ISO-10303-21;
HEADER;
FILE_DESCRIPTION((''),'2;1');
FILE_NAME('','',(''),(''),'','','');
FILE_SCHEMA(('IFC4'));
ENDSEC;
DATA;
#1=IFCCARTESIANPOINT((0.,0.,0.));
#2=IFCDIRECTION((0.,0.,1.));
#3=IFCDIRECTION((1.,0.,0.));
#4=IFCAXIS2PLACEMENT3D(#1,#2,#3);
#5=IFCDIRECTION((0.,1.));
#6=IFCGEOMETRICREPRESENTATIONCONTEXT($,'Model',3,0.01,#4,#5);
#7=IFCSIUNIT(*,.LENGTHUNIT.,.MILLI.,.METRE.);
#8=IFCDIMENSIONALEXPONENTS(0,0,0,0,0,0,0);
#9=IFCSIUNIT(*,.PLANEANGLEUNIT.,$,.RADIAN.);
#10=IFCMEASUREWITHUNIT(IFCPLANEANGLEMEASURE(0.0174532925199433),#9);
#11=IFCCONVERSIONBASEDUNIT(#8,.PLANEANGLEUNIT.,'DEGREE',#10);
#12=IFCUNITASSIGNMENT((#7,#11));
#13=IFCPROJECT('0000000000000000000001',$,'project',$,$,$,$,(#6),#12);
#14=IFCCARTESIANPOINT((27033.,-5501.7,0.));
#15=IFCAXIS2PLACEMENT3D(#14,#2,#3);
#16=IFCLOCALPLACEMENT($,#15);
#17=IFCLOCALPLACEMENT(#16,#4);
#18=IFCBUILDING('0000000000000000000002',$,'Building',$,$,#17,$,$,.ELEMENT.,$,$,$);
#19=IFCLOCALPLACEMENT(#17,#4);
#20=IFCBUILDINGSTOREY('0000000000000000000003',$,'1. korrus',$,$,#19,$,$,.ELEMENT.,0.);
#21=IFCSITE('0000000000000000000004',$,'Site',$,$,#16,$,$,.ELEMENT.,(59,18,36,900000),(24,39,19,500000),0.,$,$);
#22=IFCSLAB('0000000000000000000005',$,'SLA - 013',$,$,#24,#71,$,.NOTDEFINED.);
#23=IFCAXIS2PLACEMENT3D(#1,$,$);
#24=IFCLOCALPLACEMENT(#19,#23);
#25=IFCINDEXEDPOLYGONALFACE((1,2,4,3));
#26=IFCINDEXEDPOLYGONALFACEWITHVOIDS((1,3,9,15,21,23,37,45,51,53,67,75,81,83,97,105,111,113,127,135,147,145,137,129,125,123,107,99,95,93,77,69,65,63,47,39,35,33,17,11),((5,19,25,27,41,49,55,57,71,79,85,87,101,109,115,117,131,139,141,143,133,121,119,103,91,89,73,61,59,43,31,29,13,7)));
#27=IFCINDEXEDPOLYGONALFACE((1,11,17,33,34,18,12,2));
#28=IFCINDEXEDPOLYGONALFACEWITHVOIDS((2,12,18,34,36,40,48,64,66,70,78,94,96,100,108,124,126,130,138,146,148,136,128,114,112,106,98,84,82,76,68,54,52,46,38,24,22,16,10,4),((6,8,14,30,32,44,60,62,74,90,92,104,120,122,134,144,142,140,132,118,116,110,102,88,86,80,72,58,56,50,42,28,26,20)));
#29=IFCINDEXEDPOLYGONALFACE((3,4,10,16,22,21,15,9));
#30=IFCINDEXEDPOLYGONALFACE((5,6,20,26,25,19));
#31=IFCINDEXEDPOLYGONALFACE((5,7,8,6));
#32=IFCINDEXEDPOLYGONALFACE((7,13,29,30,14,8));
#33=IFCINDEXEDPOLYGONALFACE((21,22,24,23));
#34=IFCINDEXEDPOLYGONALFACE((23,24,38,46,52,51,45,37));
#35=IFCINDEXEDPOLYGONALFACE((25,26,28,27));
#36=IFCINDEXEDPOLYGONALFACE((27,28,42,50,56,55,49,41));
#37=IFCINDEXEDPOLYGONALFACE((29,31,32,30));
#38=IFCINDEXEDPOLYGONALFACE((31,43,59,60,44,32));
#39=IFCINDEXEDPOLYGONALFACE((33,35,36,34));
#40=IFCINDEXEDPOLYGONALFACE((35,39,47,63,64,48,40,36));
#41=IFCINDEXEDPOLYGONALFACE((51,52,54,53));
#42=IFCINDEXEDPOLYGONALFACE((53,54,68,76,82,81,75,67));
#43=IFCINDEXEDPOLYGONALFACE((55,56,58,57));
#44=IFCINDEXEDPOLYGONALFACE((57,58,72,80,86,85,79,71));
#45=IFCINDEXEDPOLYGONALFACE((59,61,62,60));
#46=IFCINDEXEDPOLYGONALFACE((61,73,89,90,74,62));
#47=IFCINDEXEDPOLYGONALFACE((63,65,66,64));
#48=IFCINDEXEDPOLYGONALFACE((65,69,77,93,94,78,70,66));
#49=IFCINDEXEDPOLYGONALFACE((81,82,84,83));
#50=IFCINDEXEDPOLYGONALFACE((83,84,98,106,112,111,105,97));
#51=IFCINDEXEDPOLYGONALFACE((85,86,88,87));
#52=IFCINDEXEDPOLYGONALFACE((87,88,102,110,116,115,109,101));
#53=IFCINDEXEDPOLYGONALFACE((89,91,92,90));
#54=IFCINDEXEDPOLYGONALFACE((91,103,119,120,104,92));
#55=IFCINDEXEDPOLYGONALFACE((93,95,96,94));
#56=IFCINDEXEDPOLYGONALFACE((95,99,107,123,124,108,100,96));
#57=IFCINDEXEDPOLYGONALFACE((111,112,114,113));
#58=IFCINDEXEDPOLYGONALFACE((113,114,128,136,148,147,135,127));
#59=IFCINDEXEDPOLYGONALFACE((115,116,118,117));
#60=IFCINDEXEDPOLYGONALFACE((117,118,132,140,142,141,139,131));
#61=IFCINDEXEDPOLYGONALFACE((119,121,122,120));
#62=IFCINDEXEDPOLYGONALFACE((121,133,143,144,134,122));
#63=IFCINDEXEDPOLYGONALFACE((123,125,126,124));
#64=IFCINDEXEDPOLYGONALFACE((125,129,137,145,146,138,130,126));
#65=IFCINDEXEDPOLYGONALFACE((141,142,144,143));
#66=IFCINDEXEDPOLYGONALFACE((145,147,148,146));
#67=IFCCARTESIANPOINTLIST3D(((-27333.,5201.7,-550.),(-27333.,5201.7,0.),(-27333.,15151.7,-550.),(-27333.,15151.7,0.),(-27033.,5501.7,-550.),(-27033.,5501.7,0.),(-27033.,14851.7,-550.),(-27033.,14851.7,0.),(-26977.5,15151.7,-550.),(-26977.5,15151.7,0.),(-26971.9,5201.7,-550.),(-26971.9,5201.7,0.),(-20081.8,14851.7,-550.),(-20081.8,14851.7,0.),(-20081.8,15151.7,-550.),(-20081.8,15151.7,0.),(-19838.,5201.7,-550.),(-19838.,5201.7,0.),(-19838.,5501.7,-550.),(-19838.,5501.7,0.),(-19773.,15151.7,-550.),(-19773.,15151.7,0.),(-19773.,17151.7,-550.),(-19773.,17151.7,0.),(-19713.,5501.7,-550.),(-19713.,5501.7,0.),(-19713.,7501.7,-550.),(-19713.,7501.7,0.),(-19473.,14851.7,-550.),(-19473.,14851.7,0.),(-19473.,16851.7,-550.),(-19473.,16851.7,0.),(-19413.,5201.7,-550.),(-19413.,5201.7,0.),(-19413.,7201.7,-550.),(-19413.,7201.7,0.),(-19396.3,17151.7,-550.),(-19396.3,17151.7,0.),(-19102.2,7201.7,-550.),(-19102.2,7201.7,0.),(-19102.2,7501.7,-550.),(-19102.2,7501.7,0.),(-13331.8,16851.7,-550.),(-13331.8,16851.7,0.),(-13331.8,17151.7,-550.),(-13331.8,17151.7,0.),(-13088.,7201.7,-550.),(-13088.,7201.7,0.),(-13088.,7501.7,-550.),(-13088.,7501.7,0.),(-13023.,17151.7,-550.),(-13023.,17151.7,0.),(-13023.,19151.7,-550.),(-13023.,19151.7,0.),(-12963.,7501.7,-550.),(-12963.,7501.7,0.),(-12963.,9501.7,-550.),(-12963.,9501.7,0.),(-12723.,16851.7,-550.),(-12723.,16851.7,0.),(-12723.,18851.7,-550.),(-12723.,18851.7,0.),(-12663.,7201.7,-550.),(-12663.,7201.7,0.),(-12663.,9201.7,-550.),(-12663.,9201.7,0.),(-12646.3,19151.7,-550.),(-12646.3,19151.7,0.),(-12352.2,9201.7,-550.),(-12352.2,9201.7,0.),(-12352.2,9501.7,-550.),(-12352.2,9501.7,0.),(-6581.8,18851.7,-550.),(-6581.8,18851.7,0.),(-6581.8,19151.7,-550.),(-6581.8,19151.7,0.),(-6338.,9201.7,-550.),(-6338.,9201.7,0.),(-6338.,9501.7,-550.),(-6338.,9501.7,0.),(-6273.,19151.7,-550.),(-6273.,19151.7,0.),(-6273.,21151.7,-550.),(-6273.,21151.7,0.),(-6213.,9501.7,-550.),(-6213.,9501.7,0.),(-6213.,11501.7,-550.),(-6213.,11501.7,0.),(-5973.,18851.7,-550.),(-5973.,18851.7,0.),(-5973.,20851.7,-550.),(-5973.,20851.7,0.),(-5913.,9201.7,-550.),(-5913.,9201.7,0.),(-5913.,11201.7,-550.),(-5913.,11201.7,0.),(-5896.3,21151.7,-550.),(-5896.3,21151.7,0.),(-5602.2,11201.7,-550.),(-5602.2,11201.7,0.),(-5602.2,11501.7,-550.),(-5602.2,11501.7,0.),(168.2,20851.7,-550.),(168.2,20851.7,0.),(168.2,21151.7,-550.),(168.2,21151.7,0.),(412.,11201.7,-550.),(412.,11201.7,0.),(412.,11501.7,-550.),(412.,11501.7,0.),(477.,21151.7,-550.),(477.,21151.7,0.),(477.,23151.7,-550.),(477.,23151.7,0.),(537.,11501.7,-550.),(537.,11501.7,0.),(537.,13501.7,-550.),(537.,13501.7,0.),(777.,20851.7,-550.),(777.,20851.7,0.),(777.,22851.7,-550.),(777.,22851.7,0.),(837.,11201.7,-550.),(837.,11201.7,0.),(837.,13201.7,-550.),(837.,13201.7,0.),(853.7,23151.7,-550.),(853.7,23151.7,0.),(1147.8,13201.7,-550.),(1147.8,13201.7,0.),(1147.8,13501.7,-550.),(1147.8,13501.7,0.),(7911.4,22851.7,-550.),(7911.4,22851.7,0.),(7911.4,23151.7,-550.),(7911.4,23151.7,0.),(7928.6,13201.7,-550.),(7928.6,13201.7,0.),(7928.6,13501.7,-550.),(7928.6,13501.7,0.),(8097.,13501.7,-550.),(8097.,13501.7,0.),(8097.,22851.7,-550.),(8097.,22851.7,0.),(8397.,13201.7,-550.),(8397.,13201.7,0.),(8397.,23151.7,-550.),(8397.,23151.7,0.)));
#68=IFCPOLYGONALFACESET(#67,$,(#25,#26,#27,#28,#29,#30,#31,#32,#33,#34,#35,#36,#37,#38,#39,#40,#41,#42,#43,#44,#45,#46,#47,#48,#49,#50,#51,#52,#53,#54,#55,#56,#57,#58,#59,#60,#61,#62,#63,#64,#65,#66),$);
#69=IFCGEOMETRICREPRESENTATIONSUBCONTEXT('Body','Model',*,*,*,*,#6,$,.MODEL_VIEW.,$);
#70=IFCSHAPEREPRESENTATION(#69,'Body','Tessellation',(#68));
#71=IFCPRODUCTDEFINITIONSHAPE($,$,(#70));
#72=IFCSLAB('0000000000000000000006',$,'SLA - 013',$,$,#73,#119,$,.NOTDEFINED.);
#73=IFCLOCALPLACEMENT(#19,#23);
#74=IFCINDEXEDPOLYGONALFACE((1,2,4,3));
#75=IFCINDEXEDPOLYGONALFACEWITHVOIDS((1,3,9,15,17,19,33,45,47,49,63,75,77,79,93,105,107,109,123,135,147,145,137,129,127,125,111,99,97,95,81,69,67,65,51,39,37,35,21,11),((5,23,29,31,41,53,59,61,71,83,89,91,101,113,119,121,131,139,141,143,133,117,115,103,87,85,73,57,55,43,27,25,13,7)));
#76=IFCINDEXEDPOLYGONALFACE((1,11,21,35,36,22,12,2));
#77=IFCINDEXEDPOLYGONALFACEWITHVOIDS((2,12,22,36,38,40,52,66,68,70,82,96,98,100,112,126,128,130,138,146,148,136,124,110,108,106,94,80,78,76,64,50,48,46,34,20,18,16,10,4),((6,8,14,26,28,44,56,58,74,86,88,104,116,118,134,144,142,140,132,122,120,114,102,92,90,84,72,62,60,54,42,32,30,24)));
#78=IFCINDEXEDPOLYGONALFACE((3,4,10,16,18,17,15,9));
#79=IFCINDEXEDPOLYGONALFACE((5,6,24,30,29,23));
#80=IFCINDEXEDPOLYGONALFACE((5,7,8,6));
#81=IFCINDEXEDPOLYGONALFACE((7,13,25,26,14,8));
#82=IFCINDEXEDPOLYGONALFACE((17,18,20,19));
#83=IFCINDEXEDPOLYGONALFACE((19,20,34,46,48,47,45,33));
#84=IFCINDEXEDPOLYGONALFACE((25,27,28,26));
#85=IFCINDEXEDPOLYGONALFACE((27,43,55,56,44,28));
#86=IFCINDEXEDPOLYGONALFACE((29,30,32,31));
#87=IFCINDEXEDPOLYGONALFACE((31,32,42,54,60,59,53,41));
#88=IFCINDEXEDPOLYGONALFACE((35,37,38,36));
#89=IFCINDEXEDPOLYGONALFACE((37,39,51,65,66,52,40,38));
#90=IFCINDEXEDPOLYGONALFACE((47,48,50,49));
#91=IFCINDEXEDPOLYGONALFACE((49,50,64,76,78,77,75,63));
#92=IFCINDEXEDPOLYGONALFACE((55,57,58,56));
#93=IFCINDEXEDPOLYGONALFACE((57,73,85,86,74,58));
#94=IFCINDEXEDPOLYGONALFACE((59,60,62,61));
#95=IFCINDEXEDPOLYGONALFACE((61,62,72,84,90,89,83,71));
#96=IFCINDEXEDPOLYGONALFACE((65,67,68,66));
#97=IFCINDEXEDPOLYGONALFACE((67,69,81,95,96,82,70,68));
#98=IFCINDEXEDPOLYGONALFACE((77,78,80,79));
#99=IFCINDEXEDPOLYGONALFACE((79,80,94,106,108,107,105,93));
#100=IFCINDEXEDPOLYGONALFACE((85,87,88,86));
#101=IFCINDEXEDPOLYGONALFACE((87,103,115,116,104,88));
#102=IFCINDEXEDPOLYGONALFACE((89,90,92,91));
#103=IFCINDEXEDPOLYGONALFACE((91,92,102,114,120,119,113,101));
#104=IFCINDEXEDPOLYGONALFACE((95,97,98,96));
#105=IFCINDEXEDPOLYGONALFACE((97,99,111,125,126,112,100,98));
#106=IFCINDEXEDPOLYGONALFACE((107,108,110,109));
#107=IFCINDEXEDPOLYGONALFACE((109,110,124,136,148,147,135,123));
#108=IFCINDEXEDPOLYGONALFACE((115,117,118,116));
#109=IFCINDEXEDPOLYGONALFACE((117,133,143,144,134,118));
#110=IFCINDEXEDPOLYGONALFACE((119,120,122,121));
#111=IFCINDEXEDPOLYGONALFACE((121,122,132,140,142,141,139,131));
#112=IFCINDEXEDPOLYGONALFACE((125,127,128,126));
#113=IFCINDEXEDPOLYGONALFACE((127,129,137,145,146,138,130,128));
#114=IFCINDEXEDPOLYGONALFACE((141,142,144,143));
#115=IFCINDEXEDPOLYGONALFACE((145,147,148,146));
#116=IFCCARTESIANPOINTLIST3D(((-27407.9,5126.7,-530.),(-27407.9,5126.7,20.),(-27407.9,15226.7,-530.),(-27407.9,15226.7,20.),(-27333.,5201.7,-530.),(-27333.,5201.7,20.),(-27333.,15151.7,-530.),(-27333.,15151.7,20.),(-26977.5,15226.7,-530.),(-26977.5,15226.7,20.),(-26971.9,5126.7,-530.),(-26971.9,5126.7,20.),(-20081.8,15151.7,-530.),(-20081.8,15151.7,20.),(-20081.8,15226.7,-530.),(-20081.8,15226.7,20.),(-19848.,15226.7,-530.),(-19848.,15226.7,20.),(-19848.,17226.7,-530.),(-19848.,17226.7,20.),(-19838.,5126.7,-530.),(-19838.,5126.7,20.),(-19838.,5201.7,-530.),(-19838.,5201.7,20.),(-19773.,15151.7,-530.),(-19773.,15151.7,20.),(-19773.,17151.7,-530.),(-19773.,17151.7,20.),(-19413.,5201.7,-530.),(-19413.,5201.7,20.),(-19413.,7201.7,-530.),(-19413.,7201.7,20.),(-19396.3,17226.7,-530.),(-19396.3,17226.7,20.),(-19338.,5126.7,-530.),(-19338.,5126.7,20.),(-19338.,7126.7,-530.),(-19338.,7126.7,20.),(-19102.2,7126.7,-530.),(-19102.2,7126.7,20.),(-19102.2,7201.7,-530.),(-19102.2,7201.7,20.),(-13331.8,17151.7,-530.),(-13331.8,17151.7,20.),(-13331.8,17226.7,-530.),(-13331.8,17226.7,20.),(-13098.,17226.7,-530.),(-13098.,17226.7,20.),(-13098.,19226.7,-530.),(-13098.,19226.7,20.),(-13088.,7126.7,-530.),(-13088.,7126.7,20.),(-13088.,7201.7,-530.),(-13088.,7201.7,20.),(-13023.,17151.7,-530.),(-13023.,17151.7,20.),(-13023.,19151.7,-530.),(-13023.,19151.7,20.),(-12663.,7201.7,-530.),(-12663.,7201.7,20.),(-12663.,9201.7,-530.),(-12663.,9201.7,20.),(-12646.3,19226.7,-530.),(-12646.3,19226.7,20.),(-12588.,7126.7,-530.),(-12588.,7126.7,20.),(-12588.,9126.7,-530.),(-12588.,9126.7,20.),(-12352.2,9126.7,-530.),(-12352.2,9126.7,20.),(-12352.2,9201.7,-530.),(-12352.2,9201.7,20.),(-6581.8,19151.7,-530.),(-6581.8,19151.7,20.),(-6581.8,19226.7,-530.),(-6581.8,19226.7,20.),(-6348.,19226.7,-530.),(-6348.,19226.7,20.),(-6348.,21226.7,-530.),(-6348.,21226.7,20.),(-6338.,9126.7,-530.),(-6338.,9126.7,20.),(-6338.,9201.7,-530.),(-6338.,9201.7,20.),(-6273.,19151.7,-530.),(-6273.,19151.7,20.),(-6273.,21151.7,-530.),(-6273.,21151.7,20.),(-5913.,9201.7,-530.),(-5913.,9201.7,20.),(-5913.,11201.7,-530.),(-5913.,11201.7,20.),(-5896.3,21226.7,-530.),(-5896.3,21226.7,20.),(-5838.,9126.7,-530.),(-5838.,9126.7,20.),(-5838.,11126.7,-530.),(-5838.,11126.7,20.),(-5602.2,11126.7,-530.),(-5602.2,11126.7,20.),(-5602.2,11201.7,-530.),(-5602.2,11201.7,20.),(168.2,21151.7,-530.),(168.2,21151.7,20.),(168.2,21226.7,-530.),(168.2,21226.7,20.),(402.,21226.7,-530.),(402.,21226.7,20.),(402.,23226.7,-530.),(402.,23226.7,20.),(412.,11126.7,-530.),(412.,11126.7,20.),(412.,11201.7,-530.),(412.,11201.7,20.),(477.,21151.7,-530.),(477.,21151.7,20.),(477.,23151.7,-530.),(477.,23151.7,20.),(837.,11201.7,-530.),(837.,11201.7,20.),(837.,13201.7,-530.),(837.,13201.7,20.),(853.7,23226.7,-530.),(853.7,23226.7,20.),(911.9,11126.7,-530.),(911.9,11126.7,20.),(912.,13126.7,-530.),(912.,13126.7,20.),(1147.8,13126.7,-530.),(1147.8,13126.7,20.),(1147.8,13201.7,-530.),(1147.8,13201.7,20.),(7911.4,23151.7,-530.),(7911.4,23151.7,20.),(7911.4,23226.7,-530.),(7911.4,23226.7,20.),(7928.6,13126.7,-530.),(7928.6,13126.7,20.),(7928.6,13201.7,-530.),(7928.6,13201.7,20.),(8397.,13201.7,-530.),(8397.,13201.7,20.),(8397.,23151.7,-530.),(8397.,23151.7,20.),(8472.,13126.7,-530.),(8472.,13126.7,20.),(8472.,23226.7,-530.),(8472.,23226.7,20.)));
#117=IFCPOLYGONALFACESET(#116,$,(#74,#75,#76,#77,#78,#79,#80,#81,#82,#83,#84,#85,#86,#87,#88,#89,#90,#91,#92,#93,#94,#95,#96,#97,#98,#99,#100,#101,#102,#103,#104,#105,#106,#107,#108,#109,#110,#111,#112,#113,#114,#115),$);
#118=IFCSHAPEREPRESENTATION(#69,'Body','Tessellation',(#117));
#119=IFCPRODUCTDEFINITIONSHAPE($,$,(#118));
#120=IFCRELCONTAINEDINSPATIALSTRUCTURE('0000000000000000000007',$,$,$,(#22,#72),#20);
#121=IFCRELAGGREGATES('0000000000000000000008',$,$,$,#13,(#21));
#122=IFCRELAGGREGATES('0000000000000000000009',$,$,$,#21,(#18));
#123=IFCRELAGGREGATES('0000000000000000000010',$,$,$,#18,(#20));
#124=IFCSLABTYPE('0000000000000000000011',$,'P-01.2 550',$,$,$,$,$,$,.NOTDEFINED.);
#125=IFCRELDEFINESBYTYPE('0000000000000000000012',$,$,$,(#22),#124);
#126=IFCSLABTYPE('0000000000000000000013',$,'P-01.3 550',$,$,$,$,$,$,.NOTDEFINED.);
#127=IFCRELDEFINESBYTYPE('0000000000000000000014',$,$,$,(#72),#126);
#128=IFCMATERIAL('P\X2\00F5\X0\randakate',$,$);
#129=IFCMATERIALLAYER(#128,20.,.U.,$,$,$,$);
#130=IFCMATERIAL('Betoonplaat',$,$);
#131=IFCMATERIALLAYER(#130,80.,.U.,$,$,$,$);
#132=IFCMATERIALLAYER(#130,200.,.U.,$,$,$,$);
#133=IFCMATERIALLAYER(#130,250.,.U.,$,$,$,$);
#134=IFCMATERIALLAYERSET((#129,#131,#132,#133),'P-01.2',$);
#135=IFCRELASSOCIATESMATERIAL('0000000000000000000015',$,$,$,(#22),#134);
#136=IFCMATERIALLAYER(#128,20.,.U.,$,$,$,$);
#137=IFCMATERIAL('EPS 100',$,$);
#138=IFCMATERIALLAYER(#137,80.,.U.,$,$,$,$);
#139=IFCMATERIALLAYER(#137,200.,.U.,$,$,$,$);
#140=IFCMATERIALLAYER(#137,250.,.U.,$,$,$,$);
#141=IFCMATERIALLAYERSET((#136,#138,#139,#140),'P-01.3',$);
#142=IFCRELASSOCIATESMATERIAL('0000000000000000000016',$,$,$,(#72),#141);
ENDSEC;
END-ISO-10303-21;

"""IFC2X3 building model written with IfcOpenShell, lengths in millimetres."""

from ifc_helpers import new_model, entity, si_unit, converted_unit, direction, frame, origin_with_axes, place, context, subcontext, project, spatial, polyline, outline, extrude, material, layer, layer_set, layer_usage, type_object, element, save


model = new_model("IFC2X3")

# Units and contexts
model_context = context("Model", 3, precision=0.01, world=origin_with_axes(), true_north=direction((0.0, 1.0)))
body_context = subcontext(model_context, "Body", "Model", "MODEL_VIEW")
ifc_project = project(units=[si_unit("LENGTHUNIT", "METRE", prefix="MILLI"), converted_unit("PLANEANGLEUNIT", "DEGREE", entity("IfcPlaneAngleMeasure", 0.0174532925199433), si_unit("PLANEANGLEUNIT", "RADIAN"), dimensions=[0, 0, 0, 0, 0, 0, 0])], contexts=[model_context])

# Site, building, storey
site_placement = place(None, frame((27033.0, -5501.7, 0.0), z_axis=(0.0, 0.0, 1.0), x_axis=(1.0, 0.0, 0.0)))
site = spatial("IfcSite", under=ifc_project, at=site_placement, Name="Site", CompositionType="ELEMENT", RefLatitude=(59, 18, 36, 900000), RefLongitude=(24, 39, 19, 500000), RefElevation=0.0)
building_placement = place(site_placement, origin_with_axes())
building = spatial("IfcBuilding", under=site, at=building_placement, Name="Building", CompositionType="ELEMENT")
storey_placement = place(building_placement, origin_with_axes())
storey = spatial("IfcBuildingStorey", under=building, at=storey_placement, Name="1. korrus", CompositionType="ELEMENT", Elevation=0.0)

# Slabs
ifc_material_1 = material(Name="Põrandakate")
ifc_material_2 = material(Name="Betoonplaat")
ifc_material_3 = material(Name="EPS 100")
ifc_layer_1 = layer(ifc_material_1, 20.0, ventilated="UNKNOWN")
ifc_layer_2 = layer(ifc_material_2, 80.0, ventilated="UNKNOWN")
ifc_layer_3 = layer(ifc_material_2, 200.0, ventilated="UNKNOWN")
ifc_layer_4 = layer(ifc_material_2, 250.0, ventilated="UNKNOWN")
ifc_layer_set_1 = layer_set([ifc_layer_1, ifc_layer_2, ifc_layer_3, ifc_layer_4], Name="P-01.2")
ifc_layer_usage_1 = layer_usage(ifc_layer_set_1, "AXIS3", "NEGATIVE", 550.0)
slab_type_1 = type_object("IfcSlabType", Name="P-01.2 550", PredefinedType="NOTDEFINED")
slab_1_placement = place(storey_placement, frame((-26977.5, 15151.7, 0.0), z_axis=(0.0, 0.0, 1.0), x_axis=(1.0, 0.0, 0.0)))
element("IfcSlab", 1, at=slab_1_placement, inside=storey, type_object=slab_type_1, material=ifc_layer_usage_1, Name="SLA - 013", PredefinedType="NOTDEFINED", context=body_context, shape_type="SweptSolid", body=[
    extrude(outline(polyline([(0.0, 0.0), (-355.5, 0.0), (-355.5, -9950.0), (5.5, -9950.0), (7139.5, -9950.0), (7564.5, -9950.0), (7564.5, -7950.0), (7875.3, -7950.0), (13889.5, -7950.0), (14314.5, -7950.0), (14314.5, -5950.0), (14625.3, -5950.0), (20639.5, -5950.0), (21064.5, -5950.0), (21064.5, -3950.0), (21375.3, -3950.0), (27389.4, -3950.0), (27814.4, -3950.0), (27814.5, -1950.0), (28125.2, -1950.0), (34906.0, -1950.0), (35374.5, -1950.0), (35374.5, 8000.0), (34888.8, 8000.0), (27831.1, 8000.0), (27454.5, 8000.0), (27454.5, 6000.0), (27145.6, 6000.0), (21081.1, 6000.0), (20704.5, 6000.0), (20704.5, 4000.0), (20395.6, 4000.0), (14331.1, 4000.0), (13954.5, 4000.0), (13954.5, 2000.0), (13645.6, 2000.0), (7581.1, 2000.0), (7204.5, 2000.0), (7204.5, 0.0), (6895.6, 0.0), (0.0, 0.0)]), holes=[polyline([(7139.5, -9650.0), (-55.5, -9650.0), (-55.5, -300.0), (6895.6, -300.0), (7504.5, -300.0), (7504.5, 1700.0), (13645.6, 1700.0), (14254.5, 1700.0), (14254.5, 3700.0), (20395.6, 3700.0), (21004.5, 3700.0), (21004.5, 5700.0), (27145.6, 5700.0), (27754.5, 5700.0), (27754.5, 7700.0), (34888.8, 7700.0), (35074.5, 7700.0), (35074.5, -1650.0), (34906.0, -1650.0), (28125.2, -1650.0), (27514.5, -1650.0), (27514.4, -3650.0), (27389.4, -3650.0), (21375.3, -3650.0), (20764.5, -3650.0), (20764.5, -5650.0), (20639.5, -5650.0), (14625.3, -5650.0), (14014.5, -5650.0), (14014.5, -7650.0), (13889.5, -7650.0), (7875.3, -7650.0), (7264.5, -7650.0), (7264.5, -9650.0), (7139.5, -9650.0)])]), frame((0.0, 0.0, -550.0), z_axis=(0.0, 0.0, 1.0), x_axis=(1.0, 0.0, 0.0)), (0.0, 0.0, 1.0), 550.0),
])
ifc_layer_5 = layer(ifc_material_1, 20.0, ventilated="UNKNOWN")
ifc_layer_6 = layer(ifc_material_3, 80.0, ventilated="UNKNOWN")
ifc_layer_7 = layer(ifc_material_3, 200.0, ventilated="UNKNOWN")
ifc_layer_8 = layer(ifc_material_3, 250.0, ventilated="UNKNOWN")
ifc_layer_set_2 = layer_set([ifc_layer_5, ifc_layer_6, ifc_layer_7, ifc_layer_8], Name="P-01.3")
ifc_layer_usage_2 = layer_usage(ifc_layer_set_2, "AXIS3", "NEGATIVE", 550.0)
slab_type_2 = type_object("IfcSlabType", Name="P-01.3 550", PredefinedType="NOTDEFINED")
slab_2_placement = place(storey_placement, frame((-26977.5, 15226.7, 0.0), z_axis=(0.0, 0.0, 1.0), x_axis=(1.0, 0.0, 0.0)))
element("IfcSlab", 2, at=slab_2_placement, inside=storey, type_object=slab_type_2, material=ifc_layer_usage_2, Name="SLA - 013", PredefinedType="NOTDEFINED", context=body_context, shape_type="SweptSolid", body=[
    extrude(outline(polyline([(0.0, 0.0), (-430.5, 0.0), (-430.5, -10099.9), (5.5, -10099.9), (7139.5, -10099.9), (7639.4, -10099.9), (7639.4, -8099.9), (7875.3, -8099.9), (13889.5, -8099.9), (14389.4, -8099.9), (14389.4, -6099.9), (14625.3, -6099.9), (20639.5, -6099.9), (21139.4, -6099.9), (21139.4, -4099.9), (21375.3, -4099.9), (27389.4, -4099.9), (27889.4, -4099.9), (27889.4, -2099.9), (28125.2, -2099.9), (34906.0, -2099.9), (35449.4, -2099.9), (35449.4, 8000.0), (34888.8, 8000.0), (27831.1, 8000.0), (27379.5, 8000.0), (27379.5, 6000.0), (27145.6, 6000.0), (21081.1, 6000.0), (20629.5, 6000.0), (20629.5, 4000.0), (20395.6, 4000.0), (14331.1, 4000.0), (13879.5, 4000.0), (13879.5, 2000.0), (13645.6, 2000.0), (7581.1, 2000.0), (7129.5, 2000.0), (7129.5, 0.0), (6895.6, 0.0), (0.0, 0.0)]), holes=[polyline([(7139.5, -10025.0), (-355.5, -10025.0), (-355.5, -75.0), (6895.6, -75.0), (7204.5, -75.0), (7204.5, 1925.0), (13645.6, 1925.0), (13954.5, 1925.0), (13954.5, 3925.0), (20395.6, 3925.0), (20704.5, 3925.0), (20704.5, 5925.0), (27145.6, 5925.0), (27454.5, 5925.0), (27454.5, 7925.0), (34888.8, 7925.0), (35374.5, 7925.0), (35374.5, -2025.0), (34906.0, -2025.0), (28125.2, -2025.0), (27814.5, -2025.0), (27814.4, -4025.0), (27389.4, -4025.0), (21375.3, -4025.0), (21064.5, -4025.0), (21064.5, -6025.0), (20639.5, -6025.0), (14625.3, -6025.0), (14314.5, -6025.0), (14314.5, -8025.0), (13889.5, -8025.0), (7875.3, -8025.0), (7564.5, -8025.0), (7564.5, -10025.0), (7139.5, -10025.0)])]), frame((0.0, 0.0, -530.0), z_axis=(0.0, 0.0, 1.0), x_axis=(1.0, 0.0, 0.0)), (0.0, 0.0, 1.0), 550.0),
])

save(model, "model.ifc")
